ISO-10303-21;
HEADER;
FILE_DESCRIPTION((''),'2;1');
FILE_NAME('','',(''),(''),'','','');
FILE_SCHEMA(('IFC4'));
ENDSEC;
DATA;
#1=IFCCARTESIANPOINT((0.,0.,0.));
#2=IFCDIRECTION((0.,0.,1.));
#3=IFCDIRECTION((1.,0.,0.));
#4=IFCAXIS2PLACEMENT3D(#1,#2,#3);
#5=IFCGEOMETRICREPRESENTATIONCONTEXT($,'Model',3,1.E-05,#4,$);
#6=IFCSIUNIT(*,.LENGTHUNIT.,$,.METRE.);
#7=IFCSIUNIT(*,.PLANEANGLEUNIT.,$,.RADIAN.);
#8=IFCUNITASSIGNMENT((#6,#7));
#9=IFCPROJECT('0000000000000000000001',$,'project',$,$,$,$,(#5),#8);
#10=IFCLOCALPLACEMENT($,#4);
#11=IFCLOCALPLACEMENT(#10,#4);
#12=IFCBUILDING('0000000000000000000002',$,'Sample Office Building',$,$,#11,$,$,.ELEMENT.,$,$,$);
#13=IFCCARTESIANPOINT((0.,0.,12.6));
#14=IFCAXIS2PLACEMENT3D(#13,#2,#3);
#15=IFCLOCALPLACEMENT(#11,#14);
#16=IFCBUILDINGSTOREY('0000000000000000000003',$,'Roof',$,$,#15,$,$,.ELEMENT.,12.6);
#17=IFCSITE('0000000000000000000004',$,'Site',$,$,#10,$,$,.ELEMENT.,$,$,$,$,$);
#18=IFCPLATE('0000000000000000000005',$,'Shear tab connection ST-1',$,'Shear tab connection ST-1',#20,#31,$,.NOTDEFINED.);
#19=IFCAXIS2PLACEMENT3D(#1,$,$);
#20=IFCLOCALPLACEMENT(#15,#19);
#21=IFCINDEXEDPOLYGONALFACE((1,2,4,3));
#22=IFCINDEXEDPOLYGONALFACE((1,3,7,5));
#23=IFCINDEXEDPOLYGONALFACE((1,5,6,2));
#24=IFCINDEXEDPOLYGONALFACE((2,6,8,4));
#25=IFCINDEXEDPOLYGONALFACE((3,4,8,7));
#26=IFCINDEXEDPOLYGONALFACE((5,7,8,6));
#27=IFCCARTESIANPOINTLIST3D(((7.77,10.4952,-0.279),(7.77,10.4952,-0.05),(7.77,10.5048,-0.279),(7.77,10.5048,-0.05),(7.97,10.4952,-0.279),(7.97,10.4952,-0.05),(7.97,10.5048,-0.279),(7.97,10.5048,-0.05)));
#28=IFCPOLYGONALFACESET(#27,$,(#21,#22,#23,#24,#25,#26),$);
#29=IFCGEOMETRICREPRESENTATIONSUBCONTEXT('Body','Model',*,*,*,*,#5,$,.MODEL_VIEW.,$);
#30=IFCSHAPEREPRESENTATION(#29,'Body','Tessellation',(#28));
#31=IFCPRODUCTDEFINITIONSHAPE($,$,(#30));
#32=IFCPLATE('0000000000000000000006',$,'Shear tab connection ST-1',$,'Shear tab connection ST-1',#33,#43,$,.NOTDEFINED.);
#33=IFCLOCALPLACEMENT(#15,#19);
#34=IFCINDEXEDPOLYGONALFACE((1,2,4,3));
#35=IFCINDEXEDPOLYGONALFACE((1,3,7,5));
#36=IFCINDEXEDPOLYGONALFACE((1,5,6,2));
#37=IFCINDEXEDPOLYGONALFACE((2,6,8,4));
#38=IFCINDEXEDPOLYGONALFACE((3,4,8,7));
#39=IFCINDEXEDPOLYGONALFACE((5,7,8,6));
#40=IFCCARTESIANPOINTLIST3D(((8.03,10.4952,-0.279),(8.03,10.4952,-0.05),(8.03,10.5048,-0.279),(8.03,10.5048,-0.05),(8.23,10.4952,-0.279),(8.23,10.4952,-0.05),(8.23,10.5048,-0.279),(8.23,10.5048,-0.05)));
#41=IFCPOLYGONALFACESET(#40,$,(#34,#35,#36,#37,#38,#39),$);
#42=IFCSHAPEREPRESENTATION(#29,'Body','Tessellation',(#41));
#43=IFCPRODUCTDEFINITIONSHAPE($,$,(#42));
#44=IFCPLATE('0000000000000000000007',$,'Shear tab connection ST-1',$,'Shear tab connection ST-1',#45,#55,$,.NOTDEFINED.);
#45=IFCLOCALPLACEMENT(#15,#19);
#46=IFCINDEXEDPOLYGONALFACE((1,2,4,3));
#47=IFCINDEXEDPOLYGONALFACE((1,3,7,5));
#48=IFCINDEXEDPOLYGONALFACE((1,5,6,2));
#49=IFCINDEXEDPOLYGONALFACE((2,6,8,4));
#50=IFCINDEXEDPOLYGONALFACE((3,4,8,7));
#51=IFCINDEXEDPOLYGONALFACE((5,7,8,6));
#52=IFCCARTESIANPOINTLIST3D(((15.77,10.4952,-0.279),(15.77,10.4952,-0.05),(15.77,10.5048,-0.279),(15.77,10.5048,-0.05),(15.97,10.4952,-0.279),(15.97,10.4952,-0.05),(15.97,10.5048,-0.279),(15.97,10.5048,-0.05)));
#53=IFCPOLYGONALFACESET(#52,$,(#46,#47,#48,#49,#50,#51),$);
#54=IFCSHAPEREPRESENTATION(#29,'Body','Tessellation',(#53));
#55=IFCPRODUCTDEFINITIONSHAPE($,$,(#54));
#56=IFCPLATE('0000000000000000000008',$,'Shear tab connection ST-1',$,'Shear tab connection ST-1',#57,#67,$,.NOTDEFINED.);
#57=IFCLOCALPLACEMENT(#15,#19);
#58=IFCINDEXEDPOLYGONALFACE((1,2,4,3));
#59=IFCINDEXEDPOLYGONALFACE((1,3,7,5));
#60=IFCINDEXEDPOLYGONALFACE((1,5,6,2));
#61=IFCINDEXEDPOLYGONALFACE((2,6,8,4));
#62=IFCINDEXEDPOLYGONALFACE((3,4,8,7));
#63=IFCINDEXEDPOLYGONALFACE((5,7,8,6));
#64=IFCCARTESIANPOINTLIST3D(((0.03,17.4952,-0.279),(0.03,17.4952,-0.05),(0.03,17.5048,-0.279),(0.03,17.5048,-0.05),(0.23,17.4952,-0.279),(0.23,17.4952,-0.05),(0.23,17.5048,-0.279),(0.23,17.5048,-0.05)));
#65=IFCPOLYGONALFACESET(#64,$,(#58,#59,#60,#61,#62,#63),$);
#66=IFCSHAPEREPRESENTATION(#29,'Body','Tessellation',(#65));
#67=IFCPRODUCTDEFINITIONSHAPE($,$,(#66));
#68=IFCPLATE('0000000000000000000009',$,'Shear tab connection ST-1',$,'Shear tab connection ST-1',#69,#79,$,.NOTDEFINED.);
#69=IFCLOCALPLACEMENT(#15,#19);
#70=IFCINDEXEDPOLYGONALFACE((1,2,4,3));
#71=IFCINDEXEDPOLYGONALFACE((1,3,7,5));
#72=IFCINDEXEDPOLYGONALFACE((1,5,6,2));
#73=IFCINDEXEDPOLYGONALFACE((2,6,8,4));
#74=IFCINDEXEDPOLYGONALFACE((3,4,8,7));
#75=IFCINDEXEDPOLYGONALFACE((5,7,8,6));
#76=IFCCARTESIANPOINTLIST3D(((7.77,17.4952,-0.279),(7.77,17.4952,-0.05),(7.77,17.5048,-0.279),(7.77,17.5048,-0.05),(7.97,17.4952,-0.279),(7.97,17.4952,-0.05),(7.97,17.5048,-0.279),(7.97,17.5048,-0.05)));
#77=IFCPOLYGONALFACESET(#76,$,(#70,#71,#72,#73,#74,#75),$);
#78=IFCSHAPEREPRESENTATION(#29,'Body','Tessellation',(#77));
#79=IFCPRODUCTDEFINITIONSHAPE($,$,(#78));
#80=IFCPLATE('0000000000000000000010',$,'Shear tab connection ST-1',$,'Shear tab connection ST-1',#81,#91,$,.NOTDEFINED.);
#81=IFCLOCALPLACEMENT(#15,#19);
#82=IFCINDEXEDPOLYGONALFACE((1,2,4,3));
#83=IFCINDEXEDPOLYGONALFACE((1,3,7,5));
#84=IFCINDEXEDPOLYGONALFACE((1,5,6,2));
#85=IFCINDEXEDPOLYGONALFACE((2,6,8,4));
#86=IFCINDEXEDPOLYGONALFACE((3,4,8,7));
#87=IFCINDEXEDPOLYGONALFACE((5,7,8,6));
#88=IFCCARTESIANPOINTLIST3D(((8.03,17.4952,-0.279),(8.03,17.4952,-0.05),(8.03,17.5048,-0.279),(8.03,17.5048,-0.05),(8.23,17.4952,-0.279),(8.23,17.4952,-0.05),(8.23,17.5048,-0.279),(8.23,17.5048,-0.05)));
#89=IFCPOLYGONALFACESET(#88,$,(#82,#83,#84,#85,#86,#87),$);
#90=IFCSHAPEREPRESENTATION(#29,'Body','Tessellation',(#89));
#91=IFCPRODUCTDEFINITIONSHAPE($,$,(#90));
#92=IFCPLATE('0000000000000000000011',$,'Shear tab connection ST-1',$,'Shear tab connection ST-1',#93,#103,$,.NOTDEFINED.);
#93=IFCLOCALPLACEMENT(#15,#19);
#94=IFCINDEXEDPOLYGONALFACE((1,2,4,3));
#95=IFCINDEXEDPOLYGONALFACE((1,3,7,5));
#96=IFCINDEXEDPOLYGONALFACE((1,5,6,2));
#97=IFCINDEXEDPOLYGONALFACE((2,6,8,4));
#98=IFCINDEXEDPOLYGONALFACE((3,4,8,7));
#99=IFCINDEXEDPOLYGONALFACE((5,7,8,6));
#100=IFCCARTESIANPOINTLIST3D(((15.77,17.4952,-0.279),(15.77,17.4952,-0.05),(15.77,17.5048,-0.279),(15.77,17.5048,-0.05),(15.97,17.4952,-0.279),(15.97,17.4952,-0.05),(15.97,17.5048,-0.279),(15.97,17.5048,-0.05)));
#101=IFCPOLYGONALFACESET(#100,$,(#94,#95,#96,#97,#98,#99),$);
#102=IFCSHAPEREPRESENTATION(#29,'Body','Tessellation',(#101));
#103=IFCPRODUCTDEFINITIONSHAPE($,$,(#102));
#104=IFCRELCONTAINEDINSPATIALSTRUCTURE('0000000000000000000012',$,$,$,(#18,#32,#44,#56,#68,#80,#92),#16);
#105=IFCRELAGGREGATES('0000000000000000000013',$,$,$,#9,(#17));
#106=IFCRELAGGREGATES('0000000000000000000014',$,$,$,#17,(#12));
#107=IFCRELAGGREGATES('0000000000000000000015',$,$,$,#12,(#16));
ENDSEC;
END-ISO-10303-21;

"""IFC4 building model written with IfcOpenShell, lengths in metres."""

from ifc_helpers import new_model, si_unit, frame, origin_with_axes, place, context, subcontext, project, spatial, rectangle, extrude, element, save


model = new_model("IFC4")

# Units and contexts
model_context = context("Model", 3, precision=1e-05, world=origin_with_axes())
body_context = subcontext(model_context, "Body", "Model", "MODEL_VIEW")
ifc_project = project(units=[si_unit("LENGTHUNIT", "METRE"), si_unit("PLANEANGLEUNIT", "RADIAN")], contexts=[model_context])

# Site, building, storey
site_placement = place(None, origin_with_axes())
site = spatial("IfcSite", under=ifc_project, at=site_placement, Name="Site", CompositionType="ELEMENT")
building_placement = place(site_placement, origin_with_axes())
building = spatial("IfcBuilding", under=site, at=building_placement, Name="Sample Office Building", CompositionType="ELEMENT")
storey_placement = place(building_placement, frame((0.0, 0.0, 12.6), z_axis=(0.0, 0.0, 1.0), x_axis=(1.0, 0.0, 0.0)))
storey = spatial("IfcBuildingStorey", under=building, at=storey_placement, Name="Roof", CompositionType="ELEMENT", Elevation=12.6)

# Plates
plate_1_placement = place(None, frame((7.87, 10.5, 12.321), z_axis=(0.0, 0.0, 1.0), x_axis=(1.0, 0.0, 0.0)))
element("IfcPlate", 1, at=plate_1_placement, inside=storey, Name="Shear tab connection ST-1", ObjectType="Shear tab connection ST-1", PredefinedType="NOTDEFINED", context=body_context, shape_type="SweptSolid", body=[
    extrude(rectangle(XDim=0.2, YDim=0.0095), None, (0.0, 0.0, 1.0), 0.229),
])
for number, where, z_axis, x_axis, name in (
    (2, (8.13, 10.5, 12.321), (0.0, 0.0, 1.0), (1.0, 0.0, 0.0), "Shear tab connection ST-1"),
    (3, (15.87, 10.5, 12.321), (0.0, 0.0, 1.0), (1.0, 0.0, 0.0), "Shear tab connection ST-1"),
):
    element("IfcPlate", number, at=place(None, frame(where, z_axis=z_axis, x_axis=x_axis)), inside=storey, Name=name, ObjectType="Shear tab connection ST-1", PredefinedType="NOTDEFINED", context=body_context, shape_type="SweptSolid", body=[
        extrude(rectangle(XDim=0.2, YDim=0.0095), None, (0.0, 0.0, 1.0), 0.229),
    ])
plate_2_placement = place(None, frame((0.13, 17.5, 12.321), z_axis=(0.0, 0.0, 1.0), x_axis=(1.0, 0.0, 0.0)))
element("IfcPlate", 4, at=plate_2_placement, inside=storey, Name="Shear tab connection ST-1", ObjectType="Shear tab connection ST-1", PredefinedType="NOTDEFINED", context=body_context, shape_type="SweptSolid", body=[
    extrude(rectangle(XDim=0.2, YDim=0.0095), None, (0.0, 0.0, 1.0), 0.229),
])
plate_3_placement = place(None, frame((7.87, 17.5, 12.321), z_axis=(0.0, 0.0, 1.0), x_axis=(1.0, 0.0, 0.0)))
element("IfcPlate", 5, at=plate_3_placement, inside=storey, Name="Shear tab connection ST-1", ObjectType="Shear tab connection ST-1", PredefinedType="NOTDEFINED", context=body_context, shape_type="SweptSolid", body=[
    extrude(rectangle(XDim=0.2, YDim=0.0095), None, (0.0, 0.0, 1.0), 0.229),
])
for number, where, z_axis, x_axis, name in (
    (6, (8.13, 17.5, 12.321), (0.0, 0.0, 1.0), (1.0, 0.0, 0.0), "Shear tab connection ST-1"),
    (7, (15.87, 17.5, 12.321), (0.0, 0.0, 1.0), (1.0, 0.0, 0.0), "Shear tab connection ST-1"),
):
    element("IfcPlate", number, at=place(None, frame(where, z_axis=z_axis, x_axis=x_axis)), inside=storey, Name=name, ObjectType="Shear tab connection ST-1", PredefinedType="NOTDEFINED", context=body_context, shape_type="SweptSolid", body=[
        extrude(rectangle(XDim=0.2, YDim=0.0095), None, (0.0, 0.0, 1.0), 0.229),
    ])

save(model, "model.ifc")
